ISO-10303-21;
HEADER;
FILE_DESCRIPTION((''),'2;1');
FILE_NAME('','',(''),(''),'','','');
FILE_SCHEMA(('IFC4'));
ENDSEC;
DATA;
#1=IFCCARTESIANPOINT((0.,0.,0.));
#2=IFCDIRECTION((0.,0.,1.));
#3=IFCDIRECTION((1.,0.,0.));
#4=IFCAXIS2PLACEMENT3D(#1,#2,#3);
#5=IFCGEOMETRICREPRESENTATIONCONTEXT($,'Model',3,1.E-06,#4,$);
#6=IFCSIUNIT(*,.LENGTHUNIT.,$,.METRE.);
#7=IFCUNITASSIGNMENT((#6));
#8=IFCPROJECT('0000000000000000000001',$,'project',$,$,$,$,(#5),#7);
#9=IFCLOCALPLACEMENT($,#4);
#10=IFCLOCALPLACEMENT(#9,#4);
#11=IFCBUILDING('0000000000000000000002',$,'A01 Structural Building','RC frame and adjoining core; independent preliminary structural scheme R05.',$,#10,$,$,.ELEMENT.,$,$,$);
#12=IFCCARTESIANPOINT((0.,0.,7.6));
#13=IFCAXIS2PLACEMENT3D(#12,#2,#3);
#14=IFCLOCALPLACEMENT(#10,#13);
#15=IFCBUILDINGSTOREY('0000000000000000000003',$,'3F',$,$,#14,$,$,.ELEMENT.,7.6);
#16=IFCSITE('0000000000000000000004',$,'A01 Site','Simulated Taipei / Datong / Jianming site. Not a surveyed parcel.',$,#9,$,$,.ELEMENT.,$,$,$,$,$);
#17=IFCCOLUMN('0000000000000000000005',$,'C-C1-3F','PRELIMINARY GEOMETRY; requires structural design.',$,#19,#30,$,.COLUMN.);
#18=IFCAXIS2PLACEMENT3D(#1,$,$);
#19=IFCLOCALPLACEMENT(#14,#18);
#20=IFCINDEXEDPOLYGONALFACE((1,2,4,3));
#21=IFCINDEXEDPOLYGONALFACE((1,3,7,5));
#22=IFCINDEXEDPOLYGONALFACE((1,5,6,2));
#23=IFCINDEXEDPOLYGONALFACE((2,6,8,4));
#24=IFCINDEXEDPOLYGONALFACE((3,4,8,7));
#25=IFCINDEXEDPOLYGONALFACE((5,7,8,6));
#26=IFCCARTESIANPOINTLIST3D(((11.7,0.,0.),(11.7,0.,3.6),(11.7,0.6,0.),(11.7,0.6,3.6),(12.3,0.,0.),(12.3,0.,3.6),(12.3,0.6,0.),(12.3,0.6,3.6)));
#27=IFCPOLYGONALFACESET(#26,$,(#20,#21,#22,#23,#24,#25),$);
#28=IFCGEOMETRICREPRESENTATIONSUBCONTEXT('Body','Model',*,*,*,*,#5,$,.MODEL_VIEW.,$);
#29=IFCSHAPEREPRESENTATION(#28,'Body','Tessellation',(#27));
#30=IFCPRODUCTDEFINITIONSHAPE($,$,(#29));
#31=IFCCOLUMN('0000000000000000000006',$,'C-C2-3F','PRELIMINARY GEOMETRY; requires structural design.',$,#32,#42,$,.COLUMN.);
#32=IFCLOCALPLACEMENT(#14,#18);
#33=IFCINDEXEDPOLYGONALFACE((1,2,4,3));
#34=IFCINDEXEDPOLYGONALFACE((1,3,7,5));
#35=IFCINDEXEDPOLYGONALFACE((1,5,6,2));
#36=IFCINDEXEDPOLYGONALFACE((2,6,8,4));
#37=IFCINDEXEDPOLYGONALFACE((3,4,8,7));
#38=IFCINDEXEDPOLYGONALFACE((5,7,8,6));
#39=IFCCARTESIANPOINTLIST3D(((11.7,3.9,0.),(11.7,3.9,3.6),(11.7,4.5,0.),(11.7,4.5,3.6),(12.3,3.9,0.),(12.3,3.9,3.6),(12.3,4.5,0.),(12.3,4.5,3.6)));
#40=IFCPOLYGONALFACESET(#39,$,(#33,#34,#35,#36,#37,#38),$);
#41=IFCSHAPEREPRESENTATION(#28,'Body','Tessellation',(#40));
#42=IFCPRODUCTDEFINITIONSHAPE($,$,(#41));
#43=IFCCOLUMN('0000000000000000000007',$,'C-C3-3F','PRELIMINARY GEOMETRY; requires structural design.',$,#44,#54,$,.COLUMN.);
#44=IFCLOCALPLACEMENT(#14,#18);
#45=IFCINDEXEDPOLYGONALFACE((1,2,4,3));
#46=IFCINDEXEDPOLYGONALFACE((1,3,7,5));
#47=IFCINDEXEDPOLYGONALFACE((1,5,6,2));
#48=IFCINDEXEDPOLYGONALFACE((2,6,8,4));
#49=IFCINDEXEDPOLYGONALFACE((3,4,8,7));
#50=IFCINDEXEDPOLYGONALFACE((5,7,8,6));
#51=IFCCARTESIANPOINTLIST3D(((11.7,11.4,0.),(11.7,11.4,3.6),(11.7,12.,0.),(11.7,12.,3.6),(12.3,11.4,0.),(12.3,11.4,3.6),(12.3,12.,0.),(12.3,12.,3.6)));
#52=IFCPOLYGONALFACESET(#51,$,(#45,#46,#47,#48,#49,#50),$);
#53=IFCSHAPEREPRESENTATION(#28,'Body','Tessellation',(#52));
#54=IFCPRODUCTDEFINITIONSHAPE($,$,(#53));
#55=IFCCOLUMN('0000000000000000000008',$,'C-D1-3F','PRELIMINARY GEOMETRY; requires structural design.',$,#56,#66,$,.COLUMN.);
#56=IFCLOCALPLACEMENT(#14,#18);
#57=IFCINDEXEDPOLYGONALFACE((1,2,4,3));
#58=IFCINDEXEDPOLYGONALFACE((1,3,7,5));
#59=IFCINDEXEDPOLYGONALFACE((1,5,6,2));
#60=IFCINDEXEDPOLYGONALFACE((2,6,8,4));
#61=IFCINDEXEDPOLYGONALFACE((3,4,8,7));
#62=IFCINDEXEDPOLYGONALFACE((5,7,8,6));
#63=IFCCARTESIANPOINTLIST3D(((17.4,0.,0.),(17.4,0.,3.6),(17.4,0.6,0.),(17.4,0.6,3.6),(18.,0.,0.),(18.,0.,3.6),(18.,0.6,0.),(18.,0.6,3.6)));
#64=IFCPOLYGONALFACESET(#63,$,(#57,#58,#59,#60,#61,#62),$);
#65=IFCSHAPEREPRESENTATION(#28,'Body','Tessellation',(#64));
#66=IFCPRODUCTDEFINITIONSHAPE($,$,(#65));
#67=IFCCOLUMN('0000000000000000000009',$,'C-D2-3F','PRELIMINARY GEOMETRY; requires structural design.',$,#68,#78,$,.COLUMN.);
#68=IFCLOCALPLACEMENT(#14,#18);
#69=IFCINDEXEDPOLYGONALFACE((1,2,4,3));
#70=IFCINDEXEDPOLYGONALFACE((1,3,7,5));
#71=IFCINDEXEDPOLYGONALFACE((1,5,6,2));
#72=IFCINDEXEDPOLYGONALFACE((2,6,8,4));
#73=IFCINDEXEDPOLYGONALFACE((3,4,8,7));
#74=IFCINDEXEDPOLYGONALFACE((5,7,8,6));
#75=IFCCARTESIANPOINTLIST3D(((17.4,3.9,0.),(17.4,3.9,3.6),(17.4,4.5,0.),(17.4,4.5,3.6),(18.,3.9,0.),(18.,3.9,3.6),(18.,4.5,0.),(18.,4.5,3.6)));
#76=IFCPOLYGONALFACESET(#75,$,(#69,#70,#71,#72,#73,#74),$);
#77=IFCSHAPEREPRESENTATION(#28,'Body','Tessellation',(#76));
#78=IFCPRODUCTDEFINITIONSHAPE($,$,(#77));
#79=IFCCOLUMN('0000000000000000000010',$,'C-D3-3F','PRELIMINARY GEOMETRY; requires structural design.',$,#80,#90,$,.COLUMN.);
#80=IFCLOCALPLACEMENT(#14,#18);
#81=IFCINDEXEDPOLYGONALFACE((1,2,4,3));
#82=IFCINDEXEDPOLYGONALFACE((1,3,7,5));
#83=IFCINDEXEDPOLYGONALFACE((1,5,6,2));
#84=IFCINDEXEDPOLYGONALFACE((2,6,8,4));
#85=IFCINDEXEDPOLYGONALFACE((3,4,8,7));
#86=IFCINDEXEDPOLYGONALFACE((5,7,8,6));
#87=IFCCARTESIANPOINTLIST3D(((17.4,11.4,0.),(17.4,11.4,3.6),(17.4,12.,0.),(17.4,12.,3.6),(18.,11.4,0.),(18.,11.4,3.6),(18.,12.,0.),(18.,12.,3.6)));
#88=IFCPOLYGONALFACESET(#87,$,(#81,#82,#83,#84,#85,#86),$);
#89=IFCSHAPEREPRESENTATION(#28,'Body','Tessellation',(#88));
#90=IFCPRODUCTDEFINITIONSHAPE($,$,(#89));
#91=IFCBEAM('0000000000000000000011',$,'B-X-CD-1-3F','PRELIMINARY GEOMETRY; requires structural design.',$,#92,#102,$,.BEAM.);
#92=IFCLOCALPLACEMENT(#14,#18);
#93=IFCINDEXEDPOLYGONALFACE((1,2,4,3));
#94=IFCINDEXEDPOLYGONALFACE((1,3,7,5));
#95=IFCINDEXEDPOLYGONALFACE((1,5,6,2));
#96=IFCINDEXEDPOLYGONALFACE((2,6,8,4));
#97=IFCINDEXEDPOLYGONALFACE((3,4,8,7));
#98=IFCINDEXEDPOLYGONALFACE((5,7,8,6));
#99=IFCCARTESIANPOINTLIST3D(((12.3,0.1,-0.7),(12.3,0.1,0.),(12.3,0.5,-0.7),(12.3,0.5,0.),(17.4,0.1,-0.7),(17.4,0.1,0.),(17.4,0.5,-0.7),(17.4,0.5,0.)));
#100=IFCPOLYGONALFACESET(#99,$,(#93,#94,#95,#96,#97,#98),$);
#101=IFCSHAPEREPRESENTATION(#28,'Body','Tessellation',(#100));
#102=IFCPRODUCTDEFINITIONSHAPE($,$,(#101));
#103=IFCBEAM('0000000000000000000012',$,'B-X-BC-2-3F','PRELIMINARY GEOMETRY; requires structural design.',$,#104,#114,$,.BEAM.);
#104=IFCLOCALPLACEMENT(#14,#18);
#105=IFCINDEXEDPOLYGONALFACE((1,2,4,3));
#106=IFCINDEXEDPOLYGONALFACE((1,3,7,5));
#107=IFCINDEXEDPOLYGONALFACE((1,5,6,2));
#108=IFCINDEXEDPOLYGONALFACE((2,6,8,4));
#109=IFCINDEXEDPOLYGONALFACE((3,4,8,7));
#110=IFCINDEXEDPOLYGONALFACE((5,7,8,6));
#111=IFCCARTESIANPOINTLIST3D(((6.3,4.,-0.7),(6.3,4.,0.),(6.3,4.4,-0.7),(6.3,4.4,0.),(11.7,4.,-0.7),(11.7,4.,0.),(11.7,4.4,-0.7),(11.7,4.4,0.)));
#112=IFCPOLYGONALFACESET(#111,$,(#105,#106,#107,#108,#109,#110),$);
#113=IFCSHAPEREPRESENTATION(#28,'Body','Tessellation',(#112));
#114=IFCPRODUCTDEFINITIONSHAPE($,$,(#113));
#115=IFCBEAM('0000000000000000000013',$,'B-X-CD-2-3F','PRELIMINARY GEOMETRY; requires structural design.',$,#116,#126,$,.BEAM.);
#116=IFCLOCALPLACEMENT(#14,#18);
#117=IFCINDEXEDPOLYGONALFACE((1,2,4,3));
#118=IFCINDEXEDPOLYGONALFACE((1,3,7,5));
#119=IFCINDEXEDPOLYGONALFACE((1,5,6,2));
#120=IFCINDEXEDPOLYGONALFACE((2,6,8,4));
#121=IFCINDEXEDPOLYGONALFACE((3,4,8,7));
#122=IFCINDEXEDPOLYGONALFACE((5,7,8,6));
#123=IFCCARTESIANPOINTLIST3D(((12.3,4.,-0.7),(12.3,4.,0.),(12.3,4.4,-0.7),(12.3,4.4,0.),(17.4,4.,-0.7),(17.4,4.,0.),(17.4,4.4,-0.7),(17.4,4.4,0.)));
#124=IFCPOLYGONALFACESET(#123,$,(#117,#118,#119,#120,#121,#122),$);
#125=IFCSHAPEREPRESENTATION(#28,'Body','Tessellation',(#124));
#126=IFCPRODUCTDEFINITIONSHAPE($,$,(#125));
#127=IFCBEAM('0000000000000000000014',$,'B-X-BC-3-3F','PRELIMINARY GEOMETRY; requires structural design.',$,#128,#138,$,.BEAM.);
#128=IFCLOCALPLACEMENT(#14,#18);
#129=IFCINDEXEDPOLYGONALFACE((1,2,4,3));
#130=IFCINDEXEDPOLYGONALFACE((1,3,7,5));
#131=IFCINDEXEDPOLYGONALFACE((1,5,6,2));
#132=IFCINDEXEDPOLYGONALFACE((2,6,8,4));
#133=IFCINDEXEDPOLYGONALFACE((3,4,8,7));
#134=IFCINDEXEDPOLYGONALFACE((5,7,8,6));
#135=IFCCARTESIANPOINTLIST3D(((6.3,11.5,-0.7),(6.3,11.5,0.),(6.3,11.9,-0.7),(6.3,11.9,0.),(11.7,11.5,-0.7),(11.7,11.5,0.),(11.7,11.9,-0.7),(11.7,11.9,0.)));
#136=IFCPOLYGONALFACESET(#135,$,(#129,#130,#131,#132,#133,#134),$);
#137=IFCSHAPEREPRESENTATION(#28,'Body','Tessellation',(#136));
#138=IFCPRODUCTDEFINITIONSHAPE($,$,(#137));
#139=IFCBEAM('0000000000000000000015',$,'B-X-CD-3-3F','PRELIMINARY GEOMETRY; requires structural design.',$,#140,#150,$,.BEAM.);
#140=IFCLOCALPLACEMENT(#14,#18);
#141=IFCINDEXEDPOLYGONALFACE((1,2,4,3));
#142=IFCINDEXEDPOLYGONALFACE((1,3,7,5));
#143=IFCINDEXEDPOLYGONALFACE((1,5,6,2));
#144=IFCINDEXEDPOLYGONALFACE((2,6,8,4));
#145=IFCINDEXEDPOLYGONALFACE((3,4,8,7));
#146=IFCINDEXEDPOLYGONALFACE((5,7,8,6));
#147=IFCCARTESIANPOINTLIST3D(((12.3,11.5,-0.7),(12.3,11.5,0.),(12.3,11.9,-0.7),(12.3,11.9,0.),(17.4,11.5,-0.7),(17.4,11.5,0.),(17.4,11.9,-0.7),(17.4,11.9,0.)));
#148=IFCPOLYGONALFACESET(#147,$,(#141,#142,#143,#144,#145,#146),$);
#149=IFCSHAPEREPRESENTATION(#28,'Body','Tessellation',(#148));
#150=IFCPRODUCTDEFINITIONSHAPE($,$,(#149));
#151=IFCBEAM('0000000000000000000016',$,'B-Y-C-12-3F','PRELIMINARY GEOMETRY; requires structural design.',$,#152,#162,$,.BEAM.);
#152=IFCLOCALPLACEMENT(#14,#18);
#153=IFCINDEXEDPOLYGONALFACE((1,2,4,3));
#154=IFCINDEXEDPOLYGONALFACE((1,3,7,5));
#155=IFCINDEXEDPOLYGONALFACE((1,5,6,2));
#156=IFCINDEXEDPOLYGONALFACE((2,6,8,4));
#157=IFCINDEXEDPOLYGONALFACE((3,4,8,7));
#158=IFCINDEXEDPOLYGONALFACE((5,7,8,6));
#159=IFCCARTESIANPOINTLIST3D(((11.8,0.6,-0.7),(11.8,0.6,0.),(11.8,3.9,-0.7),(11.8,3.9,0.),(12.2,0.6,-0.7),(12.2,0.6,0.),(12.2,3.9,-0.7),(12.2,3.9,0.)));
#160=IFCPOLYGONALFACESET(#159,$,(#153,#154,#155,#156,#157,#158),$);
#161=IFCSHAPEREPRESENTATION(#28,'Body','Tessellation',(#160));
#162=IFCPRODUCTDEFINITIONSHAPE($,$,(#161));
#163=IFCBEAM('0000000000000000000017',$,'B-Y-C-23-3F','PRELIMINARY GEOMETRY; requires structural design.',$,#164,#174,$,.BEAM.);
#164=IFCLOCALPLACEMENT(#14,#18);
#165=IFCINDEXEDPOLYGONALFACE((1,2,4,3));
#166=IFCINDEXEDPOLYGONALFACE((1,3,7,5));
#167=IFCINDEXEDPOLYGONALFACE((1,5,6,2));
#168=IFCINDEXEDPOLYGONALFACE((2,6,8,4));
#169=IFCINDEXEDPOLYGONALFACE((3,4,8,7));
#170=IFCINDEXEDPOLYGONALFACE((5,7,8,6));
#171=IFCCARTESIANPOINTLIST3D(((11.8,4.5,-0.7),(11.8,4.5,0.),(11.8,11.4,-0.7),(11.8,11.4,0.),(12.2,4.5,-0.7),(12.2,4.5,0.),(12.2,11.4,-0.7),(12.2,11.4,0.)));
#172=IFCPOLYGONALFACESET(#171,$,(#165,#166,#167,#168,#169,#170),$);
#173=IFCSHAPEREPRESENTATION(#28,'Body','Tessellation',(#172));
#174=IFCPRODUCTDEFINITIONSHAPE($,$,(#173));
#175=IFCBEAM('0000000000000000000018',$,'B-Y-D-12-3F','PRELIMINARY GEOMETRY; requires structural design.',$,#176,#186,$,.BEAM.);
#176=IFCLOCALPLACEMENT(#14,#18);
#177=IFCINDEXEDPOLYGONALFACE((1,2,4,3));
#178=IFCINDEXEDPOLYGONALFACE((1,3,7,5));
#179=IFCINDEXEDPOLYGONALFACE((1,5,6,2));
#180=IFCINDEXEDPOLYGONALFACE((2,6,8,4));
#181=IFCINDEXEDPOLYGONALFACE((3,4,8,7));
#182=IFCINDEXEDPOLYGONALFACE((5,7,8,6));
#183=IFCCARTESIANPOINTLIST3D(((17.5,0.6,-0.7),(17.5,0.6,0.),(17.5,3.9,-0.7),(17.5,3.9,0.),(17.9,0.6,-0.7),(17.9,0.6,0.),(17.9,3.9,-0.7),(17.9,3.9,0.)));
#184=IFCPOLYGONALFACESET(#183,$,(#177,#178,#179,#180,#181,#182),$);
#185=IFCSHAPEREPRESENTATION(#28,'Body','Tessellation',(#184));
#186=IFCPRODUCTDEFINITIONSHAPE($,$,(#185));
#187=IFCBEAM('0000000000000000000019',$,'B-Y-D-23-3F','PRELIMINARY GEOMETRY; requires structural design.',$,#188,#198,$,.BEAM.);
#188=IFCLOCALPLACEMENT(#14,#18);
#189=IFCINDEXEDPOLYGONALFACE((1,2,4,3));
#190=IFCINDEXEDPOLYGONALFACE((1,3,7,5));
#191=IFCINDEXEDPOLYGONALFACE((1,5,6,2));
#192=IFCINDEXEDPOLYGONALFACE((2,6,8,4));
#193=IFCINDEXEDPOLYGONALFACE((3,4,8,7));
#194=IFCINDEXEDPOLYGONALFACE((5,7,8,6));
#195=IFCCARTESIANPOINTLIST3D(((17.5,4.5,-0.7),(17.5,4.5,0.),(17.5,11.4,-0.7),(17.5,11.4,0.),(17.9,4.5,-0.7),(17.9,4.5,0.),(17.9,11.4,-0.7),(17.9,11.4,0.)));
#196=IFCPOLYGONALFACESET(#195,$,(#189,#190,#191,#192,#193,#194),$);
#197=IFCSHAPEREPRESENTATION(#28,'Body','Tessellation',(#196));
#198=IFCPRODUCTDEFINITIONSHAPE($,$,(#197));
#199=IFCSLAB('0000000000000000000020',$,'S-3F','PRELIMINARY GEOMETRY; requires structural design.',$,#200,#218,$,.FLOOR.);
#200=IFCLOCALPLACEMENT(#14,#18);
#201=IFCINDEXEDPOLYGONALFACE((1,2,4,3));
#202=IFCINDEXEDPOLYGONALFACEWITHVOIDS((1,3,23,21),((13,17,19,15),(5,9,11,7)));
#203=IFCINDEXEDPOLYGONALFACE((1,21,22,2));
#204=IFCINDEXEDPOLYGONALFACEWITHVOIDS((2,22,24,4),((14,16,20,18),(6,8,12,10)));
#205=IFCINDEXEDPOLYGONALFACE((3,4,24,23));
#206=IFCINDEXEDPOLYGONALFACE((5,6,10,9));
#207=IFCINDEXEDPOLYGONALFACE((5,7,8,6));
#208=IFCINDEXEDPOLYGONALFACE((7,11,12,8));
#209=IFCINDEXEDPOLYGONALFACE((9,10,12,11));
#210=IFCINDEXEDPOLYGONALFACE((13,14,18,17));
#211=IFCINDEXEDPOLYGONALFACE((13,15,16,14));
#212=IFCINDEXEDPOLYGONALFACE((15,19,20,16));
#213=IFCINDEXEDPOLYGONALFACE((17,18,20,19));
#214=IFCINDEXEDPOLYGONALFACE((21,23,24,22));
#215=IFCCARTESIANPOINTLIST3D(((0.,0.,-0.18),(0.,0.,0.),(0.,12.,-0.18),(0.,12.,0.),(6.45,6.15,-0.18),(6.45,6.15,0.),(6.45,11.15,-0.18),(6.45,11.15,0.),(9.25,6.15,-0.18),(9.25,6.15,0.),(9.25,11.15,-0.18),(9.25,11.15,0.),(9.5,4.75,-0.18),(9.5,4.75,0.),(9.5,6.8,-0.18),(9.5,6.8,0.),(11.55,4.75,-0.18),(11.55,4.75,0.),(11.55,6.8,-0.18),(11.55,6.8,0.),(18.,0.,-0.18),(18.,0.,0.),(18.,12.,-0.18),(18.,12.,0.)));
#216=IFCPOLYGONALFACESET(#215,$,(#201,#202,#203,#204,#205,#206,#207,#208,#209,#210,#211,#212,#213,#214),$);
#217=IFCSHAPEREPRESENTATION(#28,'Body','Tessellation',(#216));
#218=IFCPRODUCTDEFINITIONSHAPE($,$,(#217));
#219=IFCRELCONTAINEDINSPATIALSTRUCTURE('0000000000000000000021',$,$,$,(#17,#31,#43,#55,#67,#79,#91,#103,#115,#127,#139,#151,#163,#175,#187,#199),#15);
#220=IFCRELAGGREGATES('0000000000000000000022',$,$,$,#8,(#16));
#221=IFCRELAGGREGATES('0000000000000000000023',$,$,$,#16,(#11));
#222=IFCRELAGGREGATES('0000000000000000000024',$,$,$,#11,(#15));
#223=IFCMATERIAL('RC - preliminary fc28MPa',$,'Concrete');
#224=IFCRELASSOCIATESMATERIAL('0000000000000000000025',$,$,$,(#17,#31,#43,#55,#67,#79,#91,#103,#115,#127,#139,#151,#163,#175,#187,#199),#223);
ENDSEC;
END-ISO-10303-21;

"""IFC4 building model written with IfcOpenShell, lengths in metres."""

from ifc_helpers import new_model, si_unit, frame, origin_with_axes, place, context, subcontext, project, spatial, rectangle, extrude, material, element, save


model = new_model("IFC4")

# Units and contexts
model_context = context("Model", 3, precision=1e-06, world=origin_with_axes())
body_context = subcontext(model_context, "Body", "Model", "MODEL_VIEW")
ifc_project = project(units=[si_unit("LENGTHUNIT", "METRE")], contexts=[model_context])

# Site, building, storey
site_placement = place(None, origin_with_axes())
site = spatial("IfcSite", under=ifc_project, at=site_placement, Name="A01 Site", Description="Simulated Taipei / Datong / Jianming site. Not a surveyed parcel.", CompositionType="ELEMENT")
building_placement = place(site_placement, origin_with_axes())
building = spatial("IfcBuilding", under=site, at=building_placement, Name="A01 Structural Building", Description="RC frame and adjoining core; independent preliminary structural scheme R05.", CompositionType="ELEMENT")
storey_placement = place(building_placement, frame((0.0, 0.0, 7.6), z_axis=(0.0, 0.0, 1.0), x_axis=(1.0, 0.0, 0.0)))
storey = spatial("IfcBuildingStorey", under=building, at=storey_placement, Name="3F", CompositionType="ELEMENT", Elevation=7.6)

# Columns
ifc_material = material(Name="RC - preliminary fc28MPa", Category="Concrete")
for number, where, z_axis, x_axis, name in (
    (1, (12.0, 0.3, 0.0), (0.0, 0.0, 1.0), (1.0, 0.0, 0.0), "C-C1-3F"),
    (2, (12.0, 4.2, 0.0), (0.0, 0.0, 1.0), (1.0, 0.0, 0.0), "C-C2-3F"),
    (3, (12.0, 11.7, 0.0), (0.0, 0.0, 1.0), (1.0, 0.0, 0.0), "C-C3-3F"),
    (4, (17.7, 0.3, 0.0), (0.0, 0.0, 1.0), (1.0, 0.0, 0.0), "C-D1-3F"),
    (5, (17.7, 4.2, 0.0), (0.0, 0.0, 1.0), (1.0, 0.0, 0.0), "C-D2-3F"),
    (6, (17.7, 11.7, 0.0), (0.0, 0.0, 1.0), (1.0, 0.0, 0.0), "C-D3-3F"),
):
    element("IfcColumn", number, at=place(storey_placement, frame(where, z_axis=z_axis, x_axis=x_axis)), inside=storey, material=ifc_material, Name=name, Description="PRELIMINARY GEOMETRY; requires structural design.", PredefinedType="COLUMN", context=body_context, shape_type="SweptSolid", body=[
        extrude(rectangle(XDim=0.6, YDim=0.6), origin_with_axes(), (0.0, 0.0, 1.0), 3.6),
    ])

# Beams
beam_1_placement = place(storey_placement, frame((14.85, 0.3, -0.7), z_axis=(0.0, 0.0, 1.0), x_axis=(1.0, 0.0, 0.0)))
element("IfcBeam", 7, at=beam_1_placement, inside=storey, material=ifc_material, Name="B-X-CD-1-3F", Description="PRELIMINARY GEOMETRY; requires structural design.", PredefinedType="BEAM", context=body_context, shape_type="SweptSolid", body=[
    extrude(rectangle(XDim=5.1, YDim=0.4), origin_with_axes(), (0.0, 0.0, 1.0), 0.7),
])
beam_2_placement = place(storey_placement, frame((9.0, 4.2, -0.7), z_axis=(0.0, 0.0, 1.0), x_axis=(1.0, 0.0, 0.0)))
element("IfcBeam", 8, at=beam_2_placement, inside=storey, material=ifc_material, Name="B-X-BC-2-3F", Description="PRELIMINARY GEOMETRY; requires structural design.", PredefinedType="BEAM", context=body_context, shape_type="SweptSolid", body=[
    extrude(rectangle(XDim=5.4, YDim=0.4), origin_with_axes(), (0.0, 0.0, 1.0), 0.7),
])
beam_3_placement = place(storey_placement, frame((14.85, 4.2, -0.7), z_axis=(0.0, 0.0, 1.0), x_axis=(1.0, 0.0, 0.0)))
element("IfcBeam", 9, at=beam_3_placement, inside=storey, material=ifc_material, Name="B-X-CD-2-3F", Description="PRELIMINARY GEOMETRY; requires structural design.", PredefinedType="BEAM", context=body_context, shape_type="SweptSolid", body=[
    extrude(rectangle(XDim=5.1, YDim=0.4), origin_with_axes(), (0.0, 0.0, 1.0), 0.7),
])
beam_4_placement = place(storey_placement, frame((9.0, 11.7, -0.7), z_axis=(0.0, 0.0, 1.0), x_axis=(1.0, 0.0, 0.0)))
element("IfcBeam", 10, at=beam_4_placement, inside=storey, material=ifc_material, Name="B-X-BC-3-3F", Description="PRELIMINARY GEOMETRY; requires structural design.", PredefinedType="BEAM", context=body_context, shape_type="SweptSolid", body=[
    extrude(rectangle(XDim=5.4, YDim=0.4), origin_with_axes(), (0.0, 0.0, 1.0), 0.7),
])
beam_5_placement = place(storey_placement, frame((14.85, 11.7, -0.7), z_axis=(0.0, 0.0, 1.0), x_axis=(1.0, 0.0, 0.0)))
element("IfcBeam", 11, at=beam_5_placement, inside=storey, material=ifc_material, Name="B-X-CD-3-3F", Description="PRELIMINARY GEOMETRY; requires structural design.", PredefinedType="BEAM", context=body_context, shape_type="SweptSolid", body=[
    extrude(rectangle(XDim=5.1, YDim=0.4), origin_with_axes(), (0.0, 0.0, 1.0), 0.7),
])
beam_6_placement = place(storey_placement, frame((12.0, 2.25, -0.7), z_axis=(0.0, 0.0, 1.0), x_axis=(1.0, 0.0, 0.0)))
element("IfcBeam", 12, at=beam_6_placement, inside=storey, material=ifc_material, Name="B-Y-C-12-3F", Description="PRELIMINARY GEOMETRY; requires structural design.", PredefinedType="BEAM", context=body_context, shape_type="SweptSolid", body=[
    extrude(rectangle(XDim=0.4, YDim=3.3), origin_with_axes(), (0.0, 0.0, 1.0), 0.7),
])
beam_7_placement = place(storey_placement, frame((12.0, 7.95, -0.7), z_axis=(0.0, 0.0, 1.0), x_axis=(1.0, 0.0, 0.0)))
element("IfcBeam", 13, at=beam_7_placement, inside=storey, material=ifc_material, Name="B-Y-C-23-3F", Description="PRELIMINARY GEOMETRY; requires structural design.", PredefinedType="BEAM", context=body_context, shape_type="SweptSolid", body=[
    extrude(rectangle(XDim=0.4, YDim=6.9), origin_with_axes(), (0.0, 0.0, 1.0), 0.7),
])
beam_8_placement = place(storey_placement, frame((17.7, 2.25, -0.7), z_axis=(0.0, 0.0, 1.0), x_axis=(1.0, 0.0, 0.0)))
element("IfcBeam", 14, at=beam_8_placement, inside=storey, material=ifc_material, Name="B-Y-D-12-3F", Description="PRELIMINARY GEOMETRY; requires structural design.", PredefinedType="BEAM", context=body_context, shape_type="SweptSolid", body=[
    extrude(rectangle(XDim=0.4, YDim=3.3), origin_with_axes(), (0.0, 0.0, 1.0), 0.7),
])
beam_9_placement = place(storey_placement, frame((17.7, 7.95, -0.7), z_axis=(0.0, 0.0, 1.0), x_axis=(1.0, 0.0, 0.0)))
element("IfcBeam", 15, at=beam_9_placement, inside=storey, material=ifc_material, Name="B-Y-D-23-3F", Description="PRELIMINARY GEOMETRY; requires structural design.", PredefinedType="BEAM", context=body_context, shape_type="SweptSolid", body=[
    extrude(rectangle(XDim=0.4, YDim=6.9), origin_with_axes(), (0.0, 0.0, 1.0), 0.7),
])

# Slab, openings
slab_placement = place(storey_placement, frame((9.0, 6.0, -0.18), z_axis=(0.0, 0.0, 1.0), x_axis=(1.0, 0.0, 0.0)))
slab = element("IfcSlab", 16, at=slab_placement, inside=storey, material=ifc_material, Name="S-3F", Description="PRELIMINARY GEOMETRY; requires structural design.", PredefinedType="FLOOR", context=body_context, shape_type="SweptSolid", body=[
    extrude(rectangle(XDim=18.0, YDim=12.0), origin_with_axes(), (0.0, 0.0, 1.0), 0.18),
])
opening_1_placement = place(storey_placement, frame((10.525, 5.775, -0.23), z_axis=(0.0, 0.0, 1.0), x_axis=(1.0, 0.0, 0.0)))
element("IfcOpeningElement", 17, at=opening_1_placement, cuts=slab, PredefinedType="OPENING", context=body_context, shape_type="SweptSolid", body=[
    extrude(rectangle(XDim=2.05, YDim=2.05), origin_with_axes(), (0.0, 0.0, 1.0), 0.28),
])
opening_2_placement = place(storey_placement, frame((7.85, 8.65, -0.23), z_axis=(0.0, 0.0, 1.0), x_axis=(1.0, 0.0, 0.0)))
element("IfcOpeningElement", 18, at=opening_2_placement, cuts=slab, PredefinedType="OPENING", context=body_context, shape_type="SweptSolid", body=[
    extrude(rectangle(XDim=2.8, YDim=5.0), origin_with_axes(), (0.0, 0.0, 1.0), 0.28),
])

save(model, "model.ifc")
